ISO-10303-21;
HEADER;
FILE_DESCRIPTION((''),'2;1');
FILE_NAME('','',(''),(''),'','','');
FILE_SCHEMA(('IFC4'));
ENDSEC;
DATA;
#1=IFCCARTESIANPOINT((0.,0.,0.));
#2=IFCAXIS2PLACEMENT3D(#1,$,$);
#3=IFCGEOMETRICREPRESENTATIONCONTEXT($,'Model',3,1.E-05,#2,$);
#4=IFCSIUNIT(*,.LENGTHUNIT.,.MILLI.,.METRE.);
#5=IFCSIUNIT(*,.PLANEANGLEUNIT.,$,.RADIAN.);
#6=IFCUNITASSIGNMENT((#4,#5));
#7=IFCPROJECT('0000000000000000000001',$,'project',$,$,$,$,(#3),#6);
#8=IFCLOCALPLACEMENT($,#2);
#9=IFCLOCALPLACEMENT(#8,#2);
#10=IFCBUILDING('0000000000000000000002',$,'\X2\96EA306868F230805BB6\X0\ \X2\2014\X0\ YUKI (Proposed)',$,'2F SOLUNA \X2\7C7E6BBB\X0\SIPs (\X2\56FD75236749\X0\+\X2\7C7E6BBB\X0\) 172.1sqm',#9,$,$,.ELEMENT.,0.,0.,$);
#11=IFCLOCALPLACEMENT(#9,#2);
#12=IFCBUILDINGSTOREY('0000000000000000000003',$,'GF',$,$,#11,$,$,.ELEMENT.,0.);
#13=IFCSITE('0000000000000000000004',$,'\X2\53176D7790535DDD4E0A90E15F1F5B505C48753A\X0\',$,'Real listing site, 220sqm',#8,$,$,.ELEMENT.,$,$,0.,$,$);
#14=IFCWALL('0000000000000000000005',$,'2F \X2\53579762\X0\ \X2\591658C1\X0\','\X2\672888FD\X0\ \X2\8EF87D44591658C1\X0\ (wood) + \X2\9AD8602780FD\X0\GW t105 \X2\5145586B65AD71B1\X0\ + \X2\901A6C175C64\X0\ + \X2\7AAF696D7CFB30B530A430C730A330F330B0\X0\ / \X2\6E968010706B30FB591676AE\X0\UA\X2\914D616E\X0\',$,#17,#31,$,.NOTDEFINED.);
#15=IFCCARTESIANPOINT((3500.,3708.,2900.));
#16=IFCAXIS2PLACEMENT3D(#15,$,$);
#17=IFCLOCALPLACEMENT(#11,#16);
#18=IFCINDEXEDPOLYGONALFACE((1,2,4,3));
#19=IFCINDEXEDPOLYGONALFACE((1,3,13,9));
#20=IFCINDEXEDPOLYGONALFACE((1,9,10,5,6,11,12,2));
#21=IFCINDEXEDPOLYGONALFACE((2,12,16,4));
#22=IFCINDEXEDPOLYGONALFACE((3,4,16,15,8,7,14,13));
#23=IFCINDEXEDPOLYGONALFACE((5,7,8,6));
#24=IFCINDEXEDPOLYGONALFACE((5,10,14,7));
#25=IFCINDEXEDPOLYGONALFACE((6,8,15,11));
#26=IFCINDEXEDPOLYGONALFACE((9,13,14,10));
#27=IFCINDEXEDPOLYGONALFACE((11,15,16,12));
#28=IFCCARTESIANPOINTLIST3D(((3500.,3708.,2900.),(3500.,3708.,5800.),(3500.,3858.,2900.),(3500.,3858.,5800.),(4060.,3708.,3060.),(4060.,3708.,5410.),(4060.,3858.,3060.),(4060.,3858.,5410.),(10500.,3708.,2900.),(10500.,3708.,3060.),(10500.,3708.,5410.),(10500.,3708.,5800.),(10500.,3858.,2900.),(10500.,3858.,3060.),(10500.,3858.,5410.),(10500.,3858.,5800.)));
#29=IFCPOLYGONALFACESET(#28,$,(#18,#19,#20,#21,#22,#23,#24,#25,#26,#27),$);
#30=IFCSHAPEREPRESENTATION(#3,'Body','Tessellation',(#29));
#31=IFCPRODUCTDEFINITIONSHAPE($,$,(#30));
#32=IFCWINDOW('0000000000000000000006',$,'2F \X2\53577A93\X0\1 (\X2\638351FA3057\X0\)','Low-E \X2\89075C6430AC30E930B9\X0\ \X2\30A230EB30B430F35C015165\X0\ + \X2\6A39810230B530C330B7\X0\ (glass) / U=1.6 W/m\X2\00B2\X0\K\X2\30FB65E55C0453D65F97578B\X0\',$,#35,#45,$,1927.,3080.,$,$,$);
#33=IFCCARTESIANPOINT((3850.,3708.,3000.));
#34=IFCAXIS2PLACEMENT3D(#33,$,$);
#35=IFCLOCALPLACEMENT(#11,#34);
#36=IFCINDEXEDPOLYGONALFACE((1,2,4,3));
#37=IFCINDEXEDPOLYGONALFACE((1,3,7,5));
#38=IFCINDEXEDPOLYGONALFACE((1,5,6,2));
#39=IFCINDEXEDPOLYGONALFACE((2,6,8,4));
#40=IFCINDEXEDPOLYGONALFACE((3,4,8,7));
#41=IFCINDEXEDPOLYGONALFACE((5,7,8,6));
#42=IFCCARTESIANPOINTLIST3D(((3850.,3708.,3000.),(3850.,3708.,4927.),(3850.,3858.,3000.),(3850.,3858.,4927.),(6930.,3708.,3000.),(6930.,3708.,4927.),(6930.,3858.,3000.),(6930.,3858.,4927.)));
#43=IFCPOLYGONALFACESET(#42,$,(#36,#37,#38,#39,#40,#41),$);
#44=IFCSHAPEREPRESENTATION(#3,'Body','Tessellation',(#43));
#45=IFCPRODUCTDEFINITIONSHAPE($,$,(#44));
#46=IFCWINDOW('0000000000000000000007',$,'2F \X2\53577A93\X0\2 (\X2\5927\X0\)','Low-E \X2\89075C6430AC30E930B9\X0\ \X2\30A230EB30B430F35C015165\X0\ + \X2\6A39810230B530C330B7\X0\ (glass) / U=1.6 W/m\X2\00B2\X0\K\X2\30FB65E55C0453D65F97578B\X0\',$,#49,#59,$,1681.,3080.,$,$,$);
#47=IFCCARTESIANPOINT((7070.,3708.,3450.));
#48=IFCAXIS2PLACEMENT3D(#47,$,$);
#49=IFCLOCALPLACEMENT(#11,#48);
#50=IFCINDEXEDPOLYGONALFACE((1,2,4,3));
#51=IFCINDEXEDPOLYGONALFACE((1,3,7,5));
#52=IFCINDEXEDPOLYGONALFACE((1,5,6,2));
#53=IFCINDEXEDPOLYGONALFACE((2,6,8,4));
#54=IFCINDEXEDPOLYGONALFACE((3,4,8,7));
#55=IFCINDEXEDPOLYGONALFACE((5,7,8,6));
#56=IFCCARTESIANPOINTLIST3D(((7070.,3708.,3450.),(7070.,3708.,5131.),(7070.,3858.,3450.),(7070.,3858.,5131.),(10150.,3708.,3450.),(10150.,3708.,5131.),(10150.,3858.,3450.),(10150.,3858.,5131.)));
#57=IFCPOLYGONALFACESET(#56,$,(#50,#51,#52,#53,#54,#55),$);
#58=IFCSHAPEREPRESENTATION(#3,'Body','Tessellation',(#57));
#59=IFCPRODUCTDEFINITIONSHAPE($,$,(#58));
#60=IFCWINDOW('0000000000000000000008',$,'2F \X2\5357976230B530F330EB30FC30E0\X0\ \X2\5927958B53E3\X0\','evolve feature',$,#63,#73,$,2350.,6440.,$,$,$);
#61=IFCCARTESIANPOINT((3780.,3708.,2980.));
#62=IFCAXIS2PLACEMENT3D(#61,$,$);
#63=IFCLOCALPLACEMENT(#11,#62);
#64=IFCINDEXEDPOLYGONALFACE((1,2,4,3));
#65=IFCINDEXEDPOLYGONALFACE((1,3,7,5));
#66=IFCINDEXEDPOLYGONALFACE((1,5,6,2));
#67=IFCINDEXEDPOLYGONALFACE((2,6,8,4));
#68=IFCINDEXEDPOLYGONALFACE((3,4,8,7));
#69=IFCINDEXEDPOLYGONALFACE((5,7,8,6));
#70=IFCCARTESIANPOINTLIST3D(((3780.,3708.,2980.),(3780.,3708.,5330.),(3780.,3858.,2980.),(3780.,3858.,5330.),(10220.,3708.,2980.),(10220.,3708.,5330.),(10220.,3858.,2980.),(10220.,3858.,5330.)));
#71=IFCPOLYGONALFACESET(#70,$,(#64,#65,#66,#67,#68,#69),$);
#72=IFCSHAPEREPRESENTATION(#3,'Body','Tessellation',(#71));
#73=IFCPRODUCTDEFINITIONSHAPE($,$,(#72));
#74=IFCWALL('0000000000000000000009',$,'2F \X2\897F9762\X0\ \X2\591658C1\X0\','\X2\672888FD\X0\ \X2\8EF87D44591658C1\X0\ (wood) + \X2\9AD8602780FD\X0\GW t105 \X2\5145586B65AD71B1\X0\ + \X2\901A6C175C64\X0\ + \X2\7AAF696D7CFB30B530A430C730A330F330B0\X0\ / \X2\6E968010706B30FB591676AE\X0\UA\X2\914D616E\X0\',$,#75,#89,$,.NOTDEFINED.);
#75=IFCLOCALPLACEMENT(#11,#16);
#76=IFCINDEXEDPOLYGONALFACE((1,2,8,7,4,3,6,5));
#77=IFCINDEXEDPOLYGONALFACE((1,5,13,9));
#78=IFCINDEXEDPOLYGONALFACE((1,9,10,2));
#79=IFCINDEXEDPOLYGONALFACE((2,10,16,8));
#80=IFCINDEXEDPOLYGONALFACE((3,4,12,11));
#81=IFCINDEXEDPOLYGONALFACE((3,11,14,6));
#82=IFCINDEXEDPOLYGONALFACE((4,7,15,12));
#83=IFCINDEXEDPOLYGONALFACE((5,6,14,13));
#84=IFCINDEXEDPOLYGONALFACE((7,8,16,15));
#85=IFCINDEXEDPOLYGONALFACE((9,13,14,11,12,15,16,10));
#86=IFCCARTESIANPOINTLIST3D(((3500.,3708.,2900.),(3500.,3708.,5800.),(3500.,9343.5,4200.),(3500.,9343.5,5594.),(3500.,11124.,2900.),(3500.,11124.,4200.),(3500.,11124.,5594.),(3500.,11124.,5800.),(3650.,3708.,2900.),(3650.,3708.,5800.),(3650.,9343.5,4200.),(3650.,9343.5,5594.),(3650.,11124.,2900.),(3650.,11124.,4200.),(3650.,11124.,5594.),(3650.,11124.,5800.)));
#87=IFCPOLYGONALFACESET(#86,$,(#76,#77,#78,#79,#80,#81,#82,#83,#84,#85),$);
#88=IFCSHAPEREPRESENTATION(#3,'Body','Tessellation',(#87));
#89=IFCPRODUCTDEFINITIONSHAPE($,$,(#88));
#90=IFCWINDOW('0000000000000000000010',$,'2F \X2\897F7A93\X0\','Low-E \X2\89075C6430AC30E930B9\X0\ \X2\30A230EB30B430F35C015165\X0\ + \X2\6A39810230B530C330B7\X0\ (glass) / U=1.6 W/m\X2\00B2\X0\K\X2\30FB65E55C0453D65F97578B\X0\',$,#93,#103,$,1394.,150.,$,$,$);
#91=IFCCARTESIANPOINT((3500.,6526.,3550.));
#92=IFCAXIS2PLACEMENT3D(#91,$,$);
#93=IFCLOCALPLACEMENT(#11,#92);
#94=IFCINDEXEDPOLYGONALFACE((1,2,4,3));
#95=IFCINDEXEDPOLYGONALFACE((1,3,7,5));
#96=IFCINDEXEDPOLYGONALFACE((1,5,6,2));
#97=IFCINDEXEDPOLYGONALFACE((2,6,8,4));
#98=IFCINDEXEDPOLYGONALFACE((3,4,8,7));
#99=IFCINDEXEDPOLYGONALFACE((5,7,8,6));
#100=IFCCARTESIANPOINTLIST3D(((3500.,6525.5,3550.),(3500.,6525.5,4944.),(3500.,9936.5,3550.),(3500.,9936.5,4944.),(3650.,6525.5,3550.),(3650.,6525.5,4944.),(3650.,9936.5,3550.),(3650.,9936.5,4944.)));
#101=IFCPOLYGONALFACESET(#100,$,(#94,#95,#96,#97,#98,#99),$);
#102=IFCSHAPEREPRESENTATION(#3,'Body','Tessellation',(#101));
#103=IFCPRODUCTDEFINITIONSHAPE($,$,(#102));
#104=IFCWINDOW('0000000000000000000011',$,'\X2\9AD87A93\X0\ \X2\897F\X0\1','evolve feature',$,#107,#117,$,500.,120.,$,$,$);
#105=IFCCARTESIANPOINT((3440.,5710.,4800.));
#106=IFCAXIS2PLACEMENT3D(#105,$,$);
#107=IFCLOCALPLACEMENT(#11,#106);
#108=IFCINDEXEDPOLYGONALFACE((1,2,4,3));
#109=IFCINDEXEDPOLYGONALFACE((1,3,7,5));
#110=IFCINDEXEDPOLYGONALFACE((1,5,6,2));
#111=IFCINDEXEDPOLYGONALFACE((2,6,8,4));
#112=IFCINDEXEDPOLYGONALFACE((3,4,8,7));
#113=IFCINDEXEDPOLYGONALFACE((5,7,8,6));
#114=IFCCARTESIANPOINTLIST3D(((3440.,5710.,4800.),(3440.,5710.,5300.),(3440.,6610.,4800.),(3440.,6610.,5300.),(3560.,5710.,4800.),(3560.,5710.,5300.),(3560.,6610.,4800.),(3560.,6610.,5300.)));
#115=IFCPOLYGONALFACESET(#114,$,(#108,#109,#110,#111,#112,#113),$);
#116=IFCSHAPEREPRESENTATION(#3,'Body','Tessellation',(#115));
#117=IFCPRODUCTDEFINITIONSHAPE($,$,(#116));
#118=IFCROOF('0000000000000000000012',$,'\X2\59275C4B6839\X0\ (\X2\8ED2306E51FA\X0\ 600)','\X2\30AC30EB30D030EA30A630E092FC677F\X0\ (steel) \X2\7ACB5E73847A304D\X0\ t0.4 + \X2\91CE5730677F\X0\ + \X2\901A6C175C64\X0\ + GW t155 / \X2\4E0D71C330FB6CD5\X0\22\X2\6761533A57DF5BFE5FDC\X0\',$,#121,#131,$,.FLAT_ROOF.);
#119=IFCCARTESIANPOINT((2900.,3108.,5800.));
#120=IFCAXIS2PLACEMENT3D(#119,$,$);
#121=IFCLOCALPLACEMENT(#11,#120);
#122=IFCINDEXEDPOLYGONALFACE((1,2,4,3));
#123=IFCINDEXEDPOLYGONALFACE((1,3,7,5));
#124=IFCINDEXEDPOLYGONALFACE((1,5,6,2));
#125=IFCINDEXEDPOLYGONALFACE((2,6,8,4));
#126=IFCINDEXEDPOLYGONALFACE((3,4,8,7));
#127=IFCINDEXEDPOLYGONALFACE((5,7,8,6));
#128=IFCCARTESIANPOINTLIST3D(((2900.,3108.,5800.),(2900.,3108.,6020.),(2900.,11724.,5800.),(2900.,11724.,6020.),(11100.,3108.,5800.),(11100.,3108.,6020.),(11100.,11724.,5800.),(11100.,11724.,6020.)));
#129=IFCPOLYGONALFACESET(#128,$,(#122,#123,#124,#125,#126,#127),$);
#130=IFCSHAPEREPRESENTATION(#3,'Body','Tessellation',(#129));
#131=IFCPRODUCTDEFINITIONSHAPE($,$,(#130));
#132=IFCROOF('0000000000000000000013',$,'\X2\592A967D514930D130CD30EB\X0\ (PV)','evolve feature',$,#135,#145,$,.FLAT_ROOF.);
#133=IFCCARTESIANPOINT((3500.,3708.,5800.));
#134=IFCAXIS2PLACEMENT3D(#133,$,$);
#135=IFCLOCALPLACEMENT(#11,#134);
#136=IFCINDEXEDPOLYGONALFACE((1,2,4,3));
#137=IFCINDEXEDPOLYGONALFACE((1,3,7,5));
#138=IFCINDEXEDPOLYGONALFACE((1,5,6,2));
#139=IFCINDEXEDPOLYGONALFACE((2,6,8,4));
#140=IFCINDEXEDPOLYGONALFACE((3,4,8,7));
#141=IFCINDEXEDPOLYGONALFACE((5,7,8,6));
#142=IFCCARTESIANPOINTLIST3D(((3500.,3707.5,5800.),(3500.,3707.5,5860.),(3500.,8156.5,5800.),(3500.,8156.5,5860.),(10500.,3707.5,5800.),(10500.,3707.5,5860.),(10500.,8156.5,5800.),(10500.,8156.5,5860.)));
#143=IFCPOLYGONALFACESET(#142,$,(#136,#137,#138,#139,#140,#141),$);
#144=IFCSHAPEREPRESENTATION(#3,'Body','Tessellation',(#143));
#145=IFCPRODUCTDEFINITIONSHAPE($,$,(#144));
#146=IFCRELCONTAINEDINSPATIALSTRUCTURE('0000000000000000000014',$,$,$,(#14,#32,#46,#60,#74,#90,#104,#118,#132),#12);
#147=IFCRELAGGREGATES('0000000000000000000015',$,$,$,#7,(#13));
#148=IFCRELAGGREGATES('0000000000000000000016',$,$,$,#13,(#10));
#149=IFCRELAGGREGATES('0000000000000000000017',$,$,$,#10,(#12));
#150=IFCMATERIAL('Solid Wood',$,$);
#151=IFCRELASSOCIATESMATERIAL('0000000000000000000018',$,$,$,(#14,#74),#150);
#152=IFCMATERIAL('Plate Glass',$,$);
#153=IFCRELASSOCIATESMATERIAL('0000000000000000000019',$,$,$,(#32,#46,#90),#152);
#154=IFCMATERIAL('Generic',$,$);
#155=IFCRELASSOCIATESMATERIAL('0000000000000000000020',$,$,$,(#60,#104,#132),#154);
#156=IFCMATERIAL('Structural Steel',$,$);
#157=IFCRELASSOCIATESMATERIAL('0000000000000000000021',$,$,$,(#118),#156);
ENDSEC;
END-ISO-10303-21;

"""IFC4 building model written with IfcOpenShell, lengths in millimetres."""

from ifc_helpers import new_model, si_unit, frame, frame_2d, origin, place, context, project, spatial, rectangle, extrude, material, element, fill, save


model = new_model("IFC4")

# Units and contexts
model_context = context("Model", 3, precision=1e-05, world=origin())
ifc_project = project(units=[si_unit("LENGTHUNIT", "METRE", prefix="MILLI"), si_unit("PLANEANGLEUNIT", "RADIAN")], contexts=[model_context])

# Site, building, storey
site_placement = place(None, origin())
site = spatial("IfcSite", under=ifc_project, at=site_placement, Name="北海道川上郡弟子屈町", ObjectType="Real listing site, 220sqm", CompositionType="ELEMENT", RefElevation=0.0)
building_placement = place(site_placement, origin())
building = spatial("IfcBuilding", under=site, at=building_placement, Name="雪と棲む家 — YUKI (Proposed)", ObjectType="2F SOLUNA 籾殻SIPs (国産杉+籾殻) 172.1sqm", CompositionType="ELEMENT", ElevationOfRefHeight=0.0, ElevationOfTerrain=0.0)
storey_placement = place(building_placement, origin())
storey = spatial("IfcBuildingStorey", under=building, at=storey_placement, Name="GF", CompositionType="ELEMENT", Elevation=0.0)

# Shared definitions
ifc_material_1 = material(Name="Solid Wood")
ifc_material_2 = material(Name="Generic")

# Shared definitions
ifc_material_3 = material(Name="Plate Glass")

# Walls, openings, windows
wall_1_placement = place(storey_placement, frame((3500.0, 3708.0, 2900.0)))
wall_1 = element("IfcWall", 1, at=wall_1_placement, inside=storey, material=ifc_material_1, Name="2F 南面 外壁", Description="木製 軸組外壁 (wood) + 高性能GW t105 充填断熱 + 通気層 + 窯業系サイディング / 準耐火・外皮UA配慮", PredefinedType="NOTDEFINED", context=model_context, shape_type="SweptSolid", body=[
    extrude(rectangle(XDim=7000.0, YDim=150.0, at=frame_2d((3500.0, 75.0))), frame((3500.0, 3708.0, 2900.0)), (0.0, 0.0, 1.0), 2900.0),
])
opening_1_placement = place(storey_placement, frame((3850.0, 3708.0, 3000.0)))
opening_1 = element("IfcOpeningElement", 2, at=opening_1_placement, cuts=wall_1, PredefinedType="NOTDEFINED", context=model_context, shape_type="SweptSolid", body=[
    extrude(rectangle(XDim=3080.0, YDim=150.0, at=frame_2d((1540.0, 75.0))), frame((3850.0, 3708.0, 3000.0)), (0.0, 0.0, 1.0), 1927.0),
])
opening_2_placement = place(storey_placement, frame((7070.0, 3708.0, 3450.0)))
opening_2 = element("IfcOpeningElement", 3, at=opening_2_placement, cuts=wall_1, PredefinedType="NOTDEFINED", context=model_context, shape_type="SweptSolid", body=[
    extrude(rectangle(XDim=3080.0, YDim=150.0, at=frame_2d((1540.0, 75.0))), frame((7070.0, 3708.0, 3450.0)), (0.0, 0.0, 1.0), 1681.0),
])
opening_3_placement = place(storey_placement, frame((3780.0, 3708.0, 2980.0)))
opening_3 = element("IfcOpeningElement", 4, at=opening_3_placement, cuts=wall_1, PredefinedType="NOTDEFINED", context=model_context, shape_type="SweptSolid", body=[
    extrude(rectangle(XDim=6440.0, YDim=150.0, at=frame_2d((3220.0, 75.0))), frame((3780.0, 3708.0, 2980.0)), (0.0, 0.0, 1.0), 2350.0),
])
window_1_placement = place(storey_placement, frame((3850.0, 3708.0, 3000.0)))
window_1 = element("IfcWindow", 5, at=window_1_placement, inside=storey, material=ifc_material_3, Name="2F 南窓1 (掃出し)", Description="Low-E 複層ガラス アルゴン封入 + 樹脂サッシ (glass) / U=1.6 W/m²K・日射取得型", OverallHeight=1927.0, OverallWidth=3080.0, context=model_context, shape_type="SweptSolid", body=[
    extrude(rectangle(XDim=3080.0, YDim=150.0, at=frame_2d((1540.0, 75.0))), frame((3850.0, 3708.0, 3000.0)), (0.0, 0.0, 1.0), 1927.0),
])
fill(opening_1, window_1)
window_2_placement = place(storey_placement, frame((7070.0, 3708.0, 3450.0)))
window_2 = element("IfcWindow", 6, at=window_2_placement, inside=storey, material=ifc_material_3, Name="2F 南窓2 (大)", Description="Low-E 複層ガラス アルゴン封入 + 樹脂サッシ (glass) / U=1.6 W/m²K・日射取得型", OverallHeight=1681.0, OverallWidth=3080.0, context=model_context, shape_type="SweptSolid", body=[
    extrude(rectangle(XDim=3080.0, YDim=150.0, at=frame_2d((1540.0, 75.0))), frame((7070.0, 3708.0, 3450.0)), (0.0, 0.0, 1.0), 1681.0),
])
fill(opening_2, window_2)
window_3_placement = place(storey_placement, frame((3780.0, 3708.0, 2980.0)))
window_3 = element("IfcWindow", 7, at=window_3_placement, inside=storey, material=ifc_material_2, Name="2F 南面サンルーム 大開口", Description="evolve feature", OverallHeight=2350.0, OverallWidth=6440.0, context=model_context, shape_type="SweptSolid", body=[
    extrude(rectangle(XDim=6440.0, YDim=150.0, at=frame_2d((3220.0, 75.0))), frame((3780.0, 3708.0, 2980.0)), (0.0, 0.0, 1.0), 2350.0),
])
fill(opening_3, window_3)
wall_2_placement = place(storey_placement, frame((3500.0, 3708.0, 2900.0)))
wall_2 = element("IfcWall", 8, at=wall_2_placement, inside=storey, material=ifc_material_1, Name="2F 西面 外壁", Description="木製 軸組外壁 (wood) + 高性能GW t105 充填断熱 + 通気層 + 窯業系サイディング / 準耐火・外皮UA配慮", PredefinedType="NOTDEFINED", context=model_context, shape_type="SweptSolid", body=[
    extrude(rectangle(XDim=150.0, YDim=7416.0, at=frame_2d((75.0, 3708.0))), frame((3500.0, 3708.0, 2900.0)), (0.0, 0.0, 1.0), 2900.0),
])
opening_4_placement = place(storey_placement, frame((3500.0, 6526.0, 3550.0)))
opening_4 = element("IfcOpeningElement", 9, at=opening_4_placement, cuts=wall_2, PredefinedType="NOTDEFINED", context=model_context, shape_type="SweptSolid", body=[
    extrude(rectangle(XDim=150.0, YDim=3411.0, at=frame_2d((75.0, 1705.0))), frame((3500.0, 6526.0, 3550.0)), (0.0, 0.0, 1.0), 1394.0),
])
opening_5_placement = place(storey_placement, frame((3440.0, 5710.0, 4800.0)))
opening_5 = element("IfcOpeningElement", 10, at=opening_5_placement, cuts=wall_2, PredefinedType="NOTDEFINED", context=model_context, shape_type="SweptSolid", body=[
    extrude(rectangle(XDim=120.0, YDim=900.0, at=frame_2d((60.0, 450.0))), frame((3440.0, 5710.0, 4800.0)), (0.0, 0.0, 1.0), 500.0),
])
window_4_placement = place(storey_placement, frame((3500.0, 6526.0, 3550.0)))
window_4 = element("IfcWindow", 11, at=window_4_placement, inside=storey, material=ifc_material_3, Name="2F 西窓", Description="Low-E 複層ガラス アルゴン封入 + 樹脂サッシ (glass) / U=1.6 W/m²K・日射取得型", OverallHeight=1394.0, OverallWidth=150.0, context=model_context, shape_type="SweptSolid", body=[
    extrude(rectangle(XDim=150.0, YDim=3411.0, at=frame_2d((75.0, 1705.0))), frame((3500.0, 6526.0, 3550.0)), (0.0, 0.0, 1.0), 1394.0),
])
fill(opening_4, window_4)
window_5_placement = place(storey_placement, frame((3440.0, 5710.0, 4800.0)))
window_5 = element("IfcWindow", 12, at=window_5_placement, inside=storey, material=ifc_material_2, Name="高窓 西1", Description="evolve feature", OverallHeight=500.0, OverallWidth=120.0, context=model_context, shape_type="SweptSolid", body=[
    extrude(rectangle(XDim=120.0, YDim=900.0, at=frame_2d((60.0, 450.0))), frame((3440.0, 5710.0, 4800.0)), (0.0, 0.0, 1.0), 500.0),
])
fill(opening_5, window_5)

# Roofs
ifc_material_4 = material(Name="Structural Steel")
roof_1_placement = place(storey_placement, frame((2900.0, 3108.0, 5800.0)))
element("IfcRoof", 13, at=roof_1_placement, inside=storey, material=ifc_material_4, Name="大屋根 (軒の出 600)", Description="ガルバリウム鋼板 (steel) 立平葺き t0.4 + 野地板 + 通気層 + GW t155 / 不燃・法22条区域対応", PredefinedType="FLAT_ROOF", context=model_context, shape_type="SweptSolid", body=[
    extrude(rectangle(XDim=8200.0, YDim=8616.0, at=frame_2d((4100.0, 4308.0))), frame((2900.0, 3108.0, 5800.0)), (0.0, 0.0, 1.0), 220.0),
])
roof_2_placement = place(storey_placement, frame((3500.0, 3708.0, 5800.0)))
element("IfcRoof", 14, at=roof_2_placement, inside=storey, material=ifc_material_2, Name="太陽光パネル (PV)", Description="evolve feature", PredefinedType="FLAT_ROOF", context=model_context, shape_type="SweptSolid", body=[
    extrude(rectangle(XDim=7000.0, YDim=4449.0, at=frame_2d((3500.0, 2224.0))), frame((3500.0, 3708.0, 5800.0)), (0.0, 0.0, 1.0), 60.0),
])

save(model, "model.ifc")
